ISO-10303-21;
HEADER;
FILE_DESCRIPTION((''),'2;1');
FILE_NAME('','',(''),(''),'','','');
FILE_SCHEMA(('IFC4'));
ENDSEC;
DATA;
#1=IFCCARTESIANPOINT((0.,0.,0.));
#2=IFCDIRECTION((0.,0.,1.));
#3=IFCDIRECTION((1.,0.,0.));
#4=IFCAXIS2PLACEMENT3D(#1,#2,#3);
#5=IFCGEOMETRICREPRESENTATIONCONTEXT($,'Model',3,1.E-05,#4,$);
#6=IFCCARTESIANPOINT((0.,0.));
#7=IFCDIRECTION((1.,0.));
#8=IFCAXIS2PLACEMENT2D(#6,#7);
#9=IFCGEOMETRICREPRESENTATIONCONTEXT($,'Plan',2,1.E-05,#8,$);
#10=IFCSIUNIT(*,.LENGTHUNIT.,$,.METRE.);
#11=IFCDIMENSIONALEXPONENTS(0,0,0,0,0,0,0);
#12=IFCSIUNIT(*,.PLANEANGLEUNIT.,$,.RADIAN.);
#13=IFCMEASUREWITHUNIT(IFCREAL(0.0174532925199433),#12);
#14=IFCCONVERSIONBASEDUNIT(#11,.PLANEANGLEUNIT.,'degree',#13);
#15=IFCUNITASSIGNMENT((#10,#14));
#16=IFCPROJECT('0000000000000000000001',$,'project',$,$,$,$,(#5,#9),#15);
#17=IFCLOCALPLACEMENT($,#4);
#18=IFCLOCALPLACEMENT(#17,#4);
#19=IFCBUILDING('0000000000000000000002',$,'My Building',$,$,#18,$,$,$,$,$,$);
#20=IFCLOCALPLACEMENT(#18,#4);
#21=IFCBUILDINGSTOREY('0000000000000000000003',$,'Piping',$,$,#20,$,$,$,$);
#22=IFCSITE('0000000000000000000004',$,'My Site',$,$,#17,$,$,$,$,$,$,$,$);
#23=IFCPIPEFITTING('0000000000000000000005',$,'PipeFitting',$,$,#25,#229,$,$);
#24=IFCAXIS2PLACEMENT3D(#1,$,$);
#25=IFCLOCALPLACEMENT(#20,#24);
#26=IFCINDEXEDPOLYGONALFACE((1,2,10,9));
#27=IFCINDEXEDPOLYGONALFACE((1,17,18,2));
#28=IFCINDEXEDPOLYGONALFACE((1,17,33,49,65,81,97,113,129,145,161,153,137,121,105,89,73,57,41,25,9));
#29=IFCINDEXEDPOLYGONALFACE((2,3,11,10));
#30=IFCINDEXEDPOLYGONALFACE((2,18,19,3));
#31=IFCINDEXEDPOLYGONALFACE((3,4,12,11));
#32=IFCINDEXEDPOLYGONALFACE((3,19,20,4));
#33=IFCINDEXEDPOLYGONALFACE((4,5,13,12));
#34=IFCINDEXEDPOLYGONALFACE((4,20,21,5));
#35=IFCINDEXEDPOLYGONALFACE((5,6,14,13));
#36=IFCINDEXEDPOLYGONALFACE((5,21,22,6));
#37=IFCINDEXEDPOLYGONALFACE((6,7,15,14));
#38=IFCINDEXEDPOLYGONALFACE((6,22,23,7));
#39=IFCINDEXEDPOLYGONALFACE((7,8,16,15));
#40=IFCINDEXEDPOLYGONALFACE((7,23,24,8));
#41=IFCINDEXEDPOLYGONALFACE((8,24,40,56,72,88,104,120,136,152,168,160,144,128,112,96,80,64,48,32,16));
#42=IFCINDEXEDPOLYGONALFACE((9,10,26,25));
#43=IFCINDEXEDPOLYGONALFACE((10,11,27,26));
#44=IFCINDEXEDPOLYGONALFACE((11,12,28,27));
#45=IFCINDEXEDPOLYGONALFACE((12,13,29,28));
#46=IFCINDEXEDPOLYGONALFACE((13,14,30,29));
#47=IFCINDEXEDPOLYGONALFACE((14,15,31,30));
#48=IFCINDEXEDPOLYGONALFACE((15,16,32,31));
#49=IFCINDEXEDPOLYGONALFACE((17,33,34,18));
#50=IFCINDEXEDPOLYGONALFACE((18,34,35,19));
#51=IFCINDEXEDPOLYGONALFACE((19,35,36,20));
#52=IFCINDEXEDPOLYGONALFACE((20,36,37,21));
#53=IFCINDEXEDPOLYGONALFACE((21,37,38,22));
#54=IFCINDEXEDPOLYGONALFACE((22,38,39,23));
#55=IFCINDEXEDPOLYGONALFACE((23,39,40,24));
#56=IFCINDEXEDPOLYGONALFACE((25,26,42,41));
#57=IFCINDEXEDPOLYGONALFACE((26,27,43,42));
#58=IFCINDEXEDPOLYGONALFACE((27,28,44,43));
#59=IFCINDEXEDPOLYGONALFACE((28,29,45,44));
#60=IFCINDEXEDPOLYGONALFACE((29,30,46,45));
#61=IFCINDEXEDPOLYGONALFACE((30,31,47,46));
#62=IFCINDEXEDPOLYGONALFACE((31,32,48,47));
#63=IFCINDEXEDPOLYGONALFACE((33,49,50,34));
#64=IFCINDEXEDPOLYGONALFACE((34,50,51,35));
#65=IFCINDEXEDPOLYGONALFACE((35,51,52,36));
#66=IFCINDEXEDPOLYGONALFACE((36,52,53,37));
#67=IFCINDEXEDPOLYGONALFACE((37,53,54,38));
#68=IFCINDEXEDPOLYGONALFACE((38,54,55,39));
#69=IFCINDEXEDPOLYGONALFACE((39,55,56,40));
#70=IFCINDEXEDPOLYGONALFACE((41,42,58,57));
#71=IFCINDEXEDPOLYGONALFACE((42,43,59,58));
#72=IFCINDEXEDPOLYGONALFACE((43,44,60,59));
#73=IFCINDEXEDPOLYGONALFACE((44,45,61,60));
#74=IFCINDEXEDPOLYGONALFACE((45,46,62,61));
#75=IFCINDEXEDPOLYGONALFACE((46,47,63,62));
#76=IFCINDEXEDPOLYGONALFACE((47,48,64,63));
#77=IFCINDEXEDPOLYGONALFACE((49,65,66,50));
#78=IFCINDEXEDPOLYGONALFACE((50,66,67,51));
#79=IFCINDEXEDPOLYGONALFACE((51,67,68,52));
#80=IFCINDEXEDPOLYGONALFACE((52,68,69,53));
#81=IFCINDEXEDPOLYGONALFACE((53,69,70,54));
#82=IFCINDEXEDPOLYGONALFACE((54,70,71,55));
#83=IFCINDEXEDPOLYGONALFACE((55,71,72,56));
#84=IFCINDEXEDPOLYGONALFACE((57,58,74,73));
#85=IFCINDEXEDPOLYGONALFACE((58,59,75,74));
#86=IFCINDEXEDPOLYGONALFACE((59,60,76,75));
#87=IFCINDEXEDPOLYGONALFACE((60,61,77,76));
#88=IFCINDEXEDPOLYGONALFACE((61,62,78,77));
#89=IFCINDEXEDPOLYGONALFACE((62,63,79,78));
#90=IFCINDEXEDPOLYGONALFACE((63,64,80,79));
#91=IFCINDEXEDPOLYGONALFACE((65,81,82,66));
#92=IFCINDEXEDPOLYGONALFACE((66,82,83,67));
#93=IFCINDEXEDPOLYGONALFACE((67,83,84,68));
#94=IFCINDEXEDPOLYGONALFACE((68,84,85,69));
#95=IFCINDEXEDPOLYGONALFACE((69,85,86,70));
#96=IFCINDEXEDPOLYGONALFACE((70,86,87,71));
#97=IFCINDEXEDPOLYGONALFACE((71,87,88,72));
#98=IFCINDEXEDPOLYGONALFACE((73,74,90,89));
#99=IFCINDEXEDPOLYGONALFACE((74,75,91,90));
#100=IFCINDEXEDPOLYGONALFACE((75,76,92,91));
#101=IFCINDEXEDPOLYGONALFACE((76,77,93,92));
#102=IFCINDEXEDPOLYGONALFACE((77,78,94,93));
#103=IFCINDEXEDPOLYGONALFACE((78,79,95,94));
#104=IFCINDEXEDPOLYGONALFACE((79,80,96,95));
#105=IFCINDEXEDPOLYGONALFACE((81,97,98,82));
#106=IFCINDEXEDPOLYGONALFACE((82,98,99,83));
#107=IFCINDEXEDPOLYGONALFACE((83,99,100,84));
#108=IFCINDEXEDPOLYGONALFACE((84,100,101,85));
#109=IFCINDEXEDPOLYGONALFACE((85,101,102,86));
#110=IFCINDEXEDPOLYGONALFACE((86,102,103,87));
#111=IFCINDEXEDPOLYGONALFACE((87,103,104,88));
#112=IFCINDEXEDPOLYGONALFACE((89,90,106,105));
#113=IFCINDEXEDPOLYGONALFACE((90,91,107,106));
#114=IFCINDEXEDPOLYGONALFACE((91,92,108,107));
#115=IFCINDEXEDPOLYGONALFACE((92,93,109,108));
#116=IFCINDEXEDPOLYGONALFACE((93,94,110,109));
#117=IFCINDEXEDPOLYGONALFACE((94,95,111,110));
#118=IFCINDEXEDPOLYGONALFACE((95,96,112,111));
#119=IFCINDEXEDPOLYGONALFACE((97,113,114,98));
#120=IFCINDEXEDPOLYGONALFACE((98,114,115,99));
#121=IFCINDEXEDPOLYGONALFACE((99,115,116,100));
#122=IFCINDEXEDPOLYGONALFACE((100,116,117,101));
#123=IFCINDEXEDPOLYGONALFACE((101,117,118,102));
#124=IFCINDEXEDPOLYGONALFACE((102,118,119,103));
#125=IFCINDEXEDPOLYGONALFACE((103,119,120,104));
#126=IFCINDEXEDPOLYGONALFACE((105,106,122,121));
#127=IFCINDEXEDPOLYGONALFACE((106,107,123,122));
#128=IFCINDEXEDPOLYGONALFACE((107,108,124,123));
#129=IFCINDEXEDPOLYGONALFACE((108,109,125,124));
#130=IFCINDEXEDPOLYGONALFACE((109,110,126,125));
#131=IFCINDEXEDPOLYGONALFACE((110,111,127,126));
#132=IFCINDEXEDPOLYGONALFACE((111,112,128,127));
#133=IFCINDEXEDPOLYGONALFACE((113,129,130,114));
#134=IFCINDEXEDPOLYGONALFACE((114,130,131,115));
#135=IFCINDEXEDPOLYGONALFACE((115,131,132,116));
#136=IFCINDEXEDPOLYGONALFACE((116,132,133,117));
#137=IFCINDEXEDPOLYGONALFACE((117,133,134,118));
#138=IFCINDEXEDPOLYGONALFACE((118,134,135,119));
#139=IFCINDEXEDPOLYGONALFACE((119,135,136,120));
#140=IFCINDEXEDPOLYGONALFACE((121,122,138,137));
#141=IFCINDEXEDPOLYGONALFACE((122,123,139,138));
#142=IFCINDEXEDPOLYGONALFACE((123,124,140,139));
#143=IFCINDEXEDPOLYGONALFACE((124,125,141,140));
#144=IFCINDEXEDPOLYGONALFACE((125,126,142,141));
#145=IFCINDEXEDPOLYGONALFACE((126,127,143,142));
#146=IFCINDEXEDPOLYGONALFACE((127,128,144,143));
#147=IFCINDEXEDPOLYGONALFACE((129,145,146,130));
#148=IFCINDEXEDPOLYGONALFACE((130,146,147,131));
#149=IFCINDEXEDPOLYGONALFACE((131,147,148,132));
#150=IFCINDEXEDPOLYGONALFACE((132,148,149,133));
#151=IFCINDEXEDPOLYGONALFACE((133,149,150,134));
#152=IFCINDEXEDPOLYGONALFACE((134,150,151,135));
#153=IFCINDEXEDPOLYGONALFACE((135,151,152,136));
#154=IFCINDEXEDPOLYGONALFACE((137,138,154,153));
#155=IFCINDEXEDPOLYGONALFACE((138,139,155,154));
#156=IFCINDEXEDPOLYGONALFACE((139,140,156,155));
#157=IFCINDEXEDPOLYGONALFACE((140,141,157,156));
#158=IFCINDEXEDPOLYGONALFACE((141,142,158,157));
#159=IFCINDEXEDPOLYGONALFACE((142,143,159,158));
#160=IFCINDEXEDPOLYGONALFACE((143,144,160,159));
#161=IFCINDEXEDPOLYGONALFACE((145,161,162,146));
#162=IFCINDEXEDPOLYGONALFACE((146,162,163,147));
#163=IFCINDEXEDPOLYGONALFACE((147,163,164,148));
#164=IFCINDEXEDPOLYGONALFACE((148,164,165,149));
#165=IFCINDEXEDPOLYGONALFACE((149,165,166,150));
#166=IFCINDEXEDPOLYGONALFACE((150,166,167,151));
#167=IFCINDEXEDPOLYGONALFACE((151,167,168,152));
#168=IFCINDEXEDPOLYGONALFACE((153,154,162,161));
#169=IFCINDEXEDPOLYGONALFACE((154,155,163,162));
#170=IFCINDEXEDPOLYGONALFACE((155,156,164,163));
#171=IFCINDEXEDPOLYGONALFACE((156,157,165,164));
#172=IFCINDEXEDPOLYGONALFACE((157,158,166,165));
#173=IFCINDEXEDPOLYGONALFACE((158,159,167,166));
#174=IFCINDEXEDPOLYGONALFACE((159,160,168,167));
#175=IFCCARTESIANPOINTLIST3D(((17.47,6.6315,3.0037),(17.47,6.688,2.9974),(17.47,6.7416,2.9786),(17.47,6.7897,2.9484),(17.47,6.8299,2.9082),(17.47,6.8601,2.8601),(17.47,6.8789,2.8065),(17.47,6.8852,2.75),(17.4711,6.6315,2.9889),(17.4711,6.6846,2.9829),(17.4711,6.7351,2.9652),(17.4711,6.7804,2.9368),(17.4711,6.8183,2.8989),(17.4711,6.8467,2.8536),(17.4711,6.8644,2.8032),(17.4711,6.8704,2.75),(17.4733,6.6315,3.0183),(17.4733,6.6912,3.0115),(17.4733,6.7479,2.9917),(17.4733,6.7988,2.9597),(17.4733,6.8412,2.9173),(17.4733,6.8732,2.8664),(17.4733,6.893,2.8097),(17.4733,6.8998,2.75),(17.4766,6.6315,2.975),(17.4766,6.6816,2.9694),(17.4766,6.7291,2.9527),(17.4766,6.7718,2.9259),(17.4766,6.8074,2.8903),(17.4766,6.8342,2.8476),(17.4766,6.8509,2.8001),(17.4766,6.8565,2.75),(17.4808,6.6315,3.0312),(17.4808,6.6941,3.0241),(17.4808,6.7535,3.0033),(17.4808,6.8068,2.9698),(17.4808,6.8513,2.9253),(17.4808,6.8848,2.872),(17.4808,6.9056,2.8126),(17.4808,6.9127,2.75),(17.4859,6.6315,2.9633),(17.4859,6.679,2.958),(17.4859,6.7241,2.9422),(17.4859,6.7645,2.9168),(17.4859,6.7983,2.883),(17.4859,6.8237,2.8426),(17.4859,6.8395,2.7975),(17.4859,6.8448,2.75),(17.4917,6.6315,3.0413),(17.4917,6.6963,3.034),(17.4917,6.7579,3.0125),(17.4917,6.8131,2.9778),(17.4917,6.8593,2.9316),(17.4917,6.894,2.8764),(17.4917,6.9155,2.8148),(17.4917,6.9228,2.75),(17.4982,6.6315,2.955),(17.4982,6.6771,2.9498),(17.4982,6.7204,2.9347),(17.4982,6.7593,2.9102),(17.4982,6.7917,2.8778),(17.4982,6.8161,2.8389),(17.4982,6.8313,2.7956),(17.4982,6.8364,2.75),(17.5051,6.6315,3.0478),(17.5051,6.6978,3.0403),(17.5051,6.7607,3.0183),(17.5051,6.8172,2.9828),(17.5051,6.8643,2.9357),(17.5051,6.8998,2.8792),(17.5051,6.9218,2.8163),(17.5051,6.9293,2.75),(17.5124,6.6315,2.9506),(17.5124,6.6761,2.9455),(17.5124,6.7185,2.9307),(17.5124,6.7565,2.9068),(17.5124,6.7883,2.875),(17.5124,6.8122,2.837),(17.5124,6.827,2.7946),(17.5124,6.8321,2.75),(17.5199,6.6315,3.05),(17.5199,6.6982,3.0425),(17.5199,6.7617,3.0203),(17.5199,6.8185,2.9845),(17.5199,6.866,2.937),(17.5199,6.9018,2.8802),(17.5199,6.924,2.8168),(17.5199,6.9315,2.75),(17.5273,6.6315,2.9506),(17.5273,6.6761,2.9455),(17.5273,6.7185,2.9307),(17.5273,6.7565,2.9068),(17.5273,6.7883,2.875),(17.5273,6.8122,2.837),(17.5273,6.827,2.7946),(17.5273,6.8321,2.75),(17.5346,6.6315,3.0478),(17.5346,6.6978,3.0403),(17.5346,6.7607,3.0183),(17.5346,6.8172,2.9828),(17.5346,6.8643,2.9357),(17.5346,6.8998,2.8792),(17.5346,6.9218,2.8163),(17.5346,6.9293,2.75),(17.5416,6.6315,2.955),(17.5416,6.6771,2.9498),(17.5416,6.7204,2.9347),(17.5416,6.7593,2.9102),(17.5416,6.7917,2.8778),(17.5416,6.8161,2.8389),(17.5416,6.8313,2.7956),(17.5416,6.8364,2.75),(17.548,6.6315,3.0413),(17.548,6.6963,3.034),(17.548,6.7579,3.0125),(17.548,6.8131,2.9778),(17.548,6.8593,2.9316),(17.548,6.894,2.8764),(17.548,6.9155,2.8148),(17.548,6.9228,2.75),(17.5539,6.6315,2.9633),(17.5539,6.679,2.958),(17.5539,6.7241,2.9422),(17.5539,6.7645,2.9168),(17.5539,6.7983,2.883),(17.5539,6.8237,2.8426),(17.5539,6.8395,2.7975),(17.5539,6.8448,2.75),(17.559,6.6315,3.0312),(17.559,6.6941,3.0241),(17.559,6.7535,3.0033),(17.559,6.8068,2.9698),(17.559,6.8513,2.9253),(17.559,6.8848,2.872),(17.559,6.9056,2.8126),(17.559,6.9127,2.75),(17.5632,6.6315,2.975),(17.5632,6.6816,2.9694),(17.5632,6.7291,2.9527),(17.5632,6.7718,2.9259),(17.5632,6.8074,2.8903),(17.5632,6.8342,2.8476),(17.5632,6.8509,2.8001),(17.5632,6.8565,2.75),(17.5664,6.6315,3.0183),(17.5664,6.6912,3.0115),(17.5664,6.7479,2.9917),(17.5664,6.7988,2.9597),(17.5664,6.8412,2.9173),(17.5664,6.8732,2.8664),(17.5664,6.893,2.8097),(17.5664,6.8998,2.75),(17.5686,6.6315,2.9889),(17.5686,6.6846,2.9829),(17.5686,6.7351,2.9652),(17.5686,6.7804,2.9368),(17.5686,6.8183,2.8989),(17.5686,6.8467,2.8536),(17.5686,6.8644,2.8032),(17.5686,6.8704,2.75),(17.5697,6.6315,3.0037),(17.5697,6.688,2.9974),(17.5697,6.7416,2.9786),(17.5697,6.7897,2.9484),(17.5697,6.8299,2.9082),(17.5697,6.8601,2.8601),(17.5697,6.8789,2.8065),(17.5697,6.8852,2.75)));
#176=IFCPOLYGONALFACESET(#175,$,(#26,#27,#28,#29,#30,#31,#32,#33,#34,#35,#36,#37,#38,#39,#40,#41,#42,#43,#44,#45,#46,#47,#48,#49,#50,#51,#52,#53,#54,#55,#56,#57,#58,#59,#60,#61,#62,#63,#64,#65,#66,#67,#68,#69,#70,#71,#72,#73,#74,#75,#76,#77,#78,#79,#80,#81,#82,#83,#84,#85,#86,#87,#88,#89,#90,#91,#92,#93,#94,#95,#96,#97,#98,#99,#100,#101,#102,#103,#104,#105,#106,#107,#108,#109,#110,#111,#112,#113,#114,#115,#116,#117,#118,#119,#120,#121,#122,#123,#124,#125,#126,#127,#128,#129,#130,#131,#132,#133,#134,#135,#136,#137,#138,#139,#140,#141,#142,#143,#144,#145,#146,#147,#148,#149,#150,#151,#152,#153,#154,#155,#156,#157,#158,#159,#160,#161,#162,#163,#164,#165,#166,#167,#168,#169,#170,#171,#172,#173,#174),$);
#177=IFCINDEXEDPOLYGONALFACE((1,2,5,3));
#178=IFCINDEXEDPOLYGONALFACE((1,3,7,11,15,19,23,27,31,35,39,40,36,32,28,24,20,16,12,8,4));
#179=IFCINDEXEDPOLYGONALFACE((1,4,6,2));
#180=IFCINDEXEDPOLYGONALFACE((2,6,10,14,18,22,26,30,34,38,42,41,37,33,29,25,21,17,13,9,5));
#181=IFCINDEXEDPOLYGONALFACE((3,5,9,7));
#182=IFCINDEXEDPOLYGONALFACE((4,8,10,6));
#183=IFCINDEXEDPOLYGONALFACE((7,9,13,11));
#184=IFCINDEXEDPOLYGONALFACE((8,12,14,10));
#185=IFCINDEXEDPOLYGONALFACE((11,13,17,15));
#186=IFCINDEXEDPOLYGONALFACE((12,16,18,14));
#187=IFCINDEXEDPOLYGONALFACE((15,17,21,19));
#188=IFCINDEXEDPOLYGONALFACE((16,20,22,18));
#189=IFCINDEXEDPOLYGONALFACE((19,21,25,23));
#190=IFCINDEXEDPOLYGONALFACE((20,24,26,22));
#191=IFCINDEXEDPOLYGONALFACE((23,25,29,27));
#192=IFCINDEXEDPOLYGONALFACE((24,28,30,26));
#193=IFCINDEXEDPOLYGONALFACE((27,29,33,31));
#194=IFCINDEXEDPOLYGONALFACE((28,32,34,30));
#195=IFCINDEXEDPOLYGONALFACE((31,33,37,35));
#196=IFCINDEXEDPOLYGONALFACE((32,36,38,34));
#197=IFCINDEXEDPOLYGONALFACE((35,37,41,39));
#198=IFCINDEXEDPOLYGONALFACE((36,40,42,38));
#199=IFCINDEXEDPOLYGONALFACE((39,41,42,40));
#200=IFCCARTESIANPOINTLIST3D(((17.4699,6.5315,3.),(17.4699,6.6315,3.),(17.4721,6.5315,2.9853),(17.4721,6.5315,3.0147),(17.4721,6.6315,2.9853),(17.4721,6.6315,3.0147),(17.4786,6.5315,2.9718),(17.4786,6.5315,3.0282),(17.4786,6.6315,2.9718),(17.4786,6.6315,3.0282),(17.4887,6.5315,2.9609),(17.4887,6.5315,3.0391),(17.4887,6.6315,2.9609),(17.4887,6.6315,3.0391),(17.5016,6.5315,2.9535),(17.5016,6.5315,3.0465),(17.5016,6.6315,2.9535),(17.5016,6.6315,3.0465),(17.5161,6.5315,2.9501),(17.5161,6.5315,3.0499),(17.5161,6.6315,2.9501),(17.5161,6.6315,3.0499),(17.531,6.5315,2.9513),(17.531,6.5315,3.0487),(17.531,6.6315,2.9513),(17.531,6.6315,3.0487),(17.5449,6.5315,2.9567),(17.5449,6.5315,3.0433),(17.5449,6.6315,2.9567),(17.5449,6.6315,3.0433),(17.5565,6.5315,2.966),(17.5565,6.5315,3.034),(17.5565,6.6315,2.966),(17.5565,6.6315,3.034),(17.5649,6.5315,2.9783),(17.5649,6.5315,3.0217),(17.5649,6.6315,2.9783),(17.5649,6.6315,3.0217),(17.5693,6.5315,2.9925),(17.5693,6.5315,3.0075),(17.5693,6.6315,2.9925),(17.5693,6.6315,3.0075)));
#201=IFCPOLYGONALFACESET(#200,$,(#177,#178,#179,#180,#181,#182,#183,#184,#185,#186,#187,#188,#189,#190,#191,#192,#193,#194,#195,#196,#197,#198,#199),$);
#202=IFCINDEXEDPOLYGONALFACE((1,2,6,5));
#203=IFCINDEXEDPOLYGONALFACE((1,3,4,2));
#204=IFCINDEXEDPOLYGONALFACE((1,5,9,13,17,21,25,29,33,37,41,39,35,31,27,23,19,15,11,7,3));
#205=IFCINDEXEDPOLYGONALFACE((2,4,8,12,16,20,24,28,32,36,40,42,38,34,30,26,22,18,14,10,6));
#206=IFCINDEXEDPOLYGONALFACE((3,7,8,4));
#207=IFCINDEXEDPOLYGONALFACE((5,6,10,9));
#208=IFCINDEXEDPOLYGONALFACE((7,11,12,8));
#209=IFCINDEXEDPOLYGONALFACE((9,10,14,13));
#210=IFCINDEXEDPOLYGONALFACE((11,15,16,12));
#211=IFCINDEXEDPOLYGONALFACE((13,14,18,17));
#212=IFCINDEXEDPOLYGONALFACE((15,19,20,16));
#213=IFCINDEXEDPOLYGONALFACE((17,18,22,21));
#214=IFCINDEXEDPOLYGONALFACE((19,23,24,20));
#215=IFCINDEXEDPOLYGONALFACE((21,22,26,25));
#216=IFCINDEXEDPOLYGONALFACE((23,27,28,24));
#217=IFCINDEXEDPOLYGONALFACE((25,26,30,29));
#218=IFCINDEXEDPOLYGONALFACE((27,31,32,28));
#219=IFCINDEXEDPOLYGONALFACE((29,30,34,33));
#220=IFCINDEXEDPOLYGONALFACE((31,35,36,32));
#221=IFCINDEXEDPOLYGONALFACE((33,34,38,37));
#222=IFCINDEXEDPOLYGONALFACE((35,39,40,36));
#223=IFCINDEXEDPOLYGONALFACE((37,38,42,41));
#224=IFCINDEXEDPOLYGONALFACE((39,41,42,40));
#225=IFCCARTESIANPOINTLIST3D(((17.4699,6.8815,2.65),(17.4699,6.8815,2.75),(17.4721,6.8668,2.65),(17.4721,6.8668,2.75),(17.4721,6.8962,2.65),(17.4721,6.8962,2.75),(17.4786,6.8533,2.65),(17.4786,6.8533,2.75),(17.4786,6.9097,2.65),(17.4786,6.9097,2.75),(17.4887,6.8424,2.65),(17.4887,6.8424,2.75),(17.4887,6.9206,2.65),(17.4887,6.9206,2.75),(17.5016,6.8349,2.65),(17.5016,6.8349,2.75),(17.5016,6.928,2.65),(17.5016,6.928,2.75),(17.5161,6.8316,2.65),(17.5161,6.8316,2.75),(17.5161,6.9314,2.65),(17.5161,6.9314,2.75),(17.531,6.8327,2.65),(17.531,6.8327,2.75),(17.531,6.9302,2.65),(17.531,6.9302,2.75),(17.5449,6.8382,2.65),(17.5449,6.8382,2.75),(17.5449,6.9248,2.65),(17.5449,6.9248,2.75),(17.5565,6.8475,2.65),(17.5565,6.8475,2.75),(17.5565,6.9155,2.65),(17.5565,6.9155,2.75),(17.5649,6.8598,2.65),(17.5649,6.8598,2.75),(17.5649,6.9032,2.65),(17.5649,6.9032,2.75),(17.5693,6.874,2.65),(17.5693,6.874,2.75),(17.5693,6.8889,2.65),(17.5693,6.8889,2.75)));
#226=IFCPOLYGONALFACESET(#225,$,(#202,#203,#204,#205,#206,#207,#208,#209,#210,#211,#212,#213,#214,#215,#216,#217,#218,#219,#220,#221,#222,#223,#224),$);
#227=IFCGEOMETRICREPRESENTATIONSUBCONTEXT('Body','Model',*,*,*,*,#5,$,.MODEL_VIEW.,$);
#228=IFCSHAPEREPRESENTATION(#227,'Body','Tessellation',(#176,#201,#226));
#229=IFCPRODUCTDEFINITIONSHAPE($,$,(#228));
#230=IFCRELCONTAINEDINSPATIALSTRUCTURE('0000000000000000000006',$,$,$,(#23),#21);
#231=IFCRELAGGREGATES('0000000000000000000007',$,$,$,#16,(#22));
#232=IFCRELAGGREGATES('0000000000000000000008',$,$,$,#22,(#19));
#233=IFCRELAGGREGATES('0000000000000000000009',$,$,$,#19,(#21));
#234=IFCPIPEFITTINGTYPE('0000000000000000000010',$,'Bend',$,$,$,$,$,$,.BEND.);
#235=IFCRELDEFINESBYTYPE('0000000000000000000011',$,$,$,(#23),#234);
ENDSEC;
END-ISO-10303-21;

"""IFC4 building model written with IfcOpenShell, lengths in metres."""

from ifc_helpers import new_model, entity, si_unit, converted_unit, frame, origin_with_axes, origin_2d_with_axis, place, context, subcontext, project, spatial, circle, extrude, source, transform, mapped, type_object, type_shapes, element, save


model = new_model("IFC4")

# Units and contexts
model_context = context("Model", 3, precision=1e-05, world=origin_with_axes())
plan_context = context("Plan", 2, precision=1e-05, world=origin_2d_with_axis())
body_context = subcontext(model_context, "Body", "Model", "MODEL_VIEW")
ifc_project = project(units=[si_unit("LENGTHUNIT", "METRE"), converted_unit("PLANEANGLEUNIT", "degree", entity("IfcReal", 0.0174532925199433), si_unit("PLANEANGLEUNIT", "RADIAN"), dimensions=[0, 0, 0, 0, 0, 0, 0])], contexts=[model_context, plan_context])

# Site, building, storey
site_placement = place(None, origin_with_axes())
site = spatial("IfcSite", under=ifc_project, at=site_placement, Name="My Site")
building_placement = place(site_placement, origin_with_axes())
building = spatial("IfcBuilding", under=site, at=building_placement, Name="My Building")
storey_placement = place(building_placement, origin_with_axes())
storey = spatial("IfcBuildingStorey", under=building, at=storey_placement, Name="Piping")

# Pipe fitting
pipe_fitting_type_1 = type_object("IfcPipeFittingType", Name="Bend", PredefinedType="BEND")
shared_shape = source(origin_with_axes(), body_context, "Body", "SolidModel", [
    entity("IfcSweptDiskSolid", entity("IfcIndexedPolyCurve", entity("IfcCartesianPointList3D", [[0.0, 0.0, -0.1], [0.0, 0.0732, -0.2768], [0.0, 0.25, -0.35]]), [entity("IfcArcIndex", [1, 2, 3])]), 0.05),
    extrude(circle(Radius=0.05), origin_with_axes(), (0.0, 0.0, -1.0), 0.1),
    extrude(circle(Radius=0.05), frame((0.0, 0.25, -0.35), z_axis=(0.0, 1.0, 0.0), x_axis=(1.0, 0.0, 0.0)), (0.0, 0.0, 1.0), 0.1),
])
type_shapes(pipe_fitting_type_1, [shared_shape])
for number, where, z_axis, x_axis, name in (
    (1, (17.5199, 6.5315, 3.0), (0.0, -1.0, 0.0), (-1.0, 0.0, 0.0), "PipeFitting"),
):
    element("IfcPipeFitting", number, at=place(storey_placement, frame(where, z_axis=z_axis, x_axis=x_axis)), inside=storey, type_object=pipe_fitting_type_1, Name=name, context=body_context, shape_type="MappedRepresentation", body=[
        mapped(shared_shape, transform((0.0, 0.0, 0.0), x_axis=(1.0, 0.0, 0.0), y_axis=(0.0, 1.0, 0.0), z_axis=(0.0, 0.0, 1.0), scale=1.0)),
    ])

save(model, "model.ifc")
